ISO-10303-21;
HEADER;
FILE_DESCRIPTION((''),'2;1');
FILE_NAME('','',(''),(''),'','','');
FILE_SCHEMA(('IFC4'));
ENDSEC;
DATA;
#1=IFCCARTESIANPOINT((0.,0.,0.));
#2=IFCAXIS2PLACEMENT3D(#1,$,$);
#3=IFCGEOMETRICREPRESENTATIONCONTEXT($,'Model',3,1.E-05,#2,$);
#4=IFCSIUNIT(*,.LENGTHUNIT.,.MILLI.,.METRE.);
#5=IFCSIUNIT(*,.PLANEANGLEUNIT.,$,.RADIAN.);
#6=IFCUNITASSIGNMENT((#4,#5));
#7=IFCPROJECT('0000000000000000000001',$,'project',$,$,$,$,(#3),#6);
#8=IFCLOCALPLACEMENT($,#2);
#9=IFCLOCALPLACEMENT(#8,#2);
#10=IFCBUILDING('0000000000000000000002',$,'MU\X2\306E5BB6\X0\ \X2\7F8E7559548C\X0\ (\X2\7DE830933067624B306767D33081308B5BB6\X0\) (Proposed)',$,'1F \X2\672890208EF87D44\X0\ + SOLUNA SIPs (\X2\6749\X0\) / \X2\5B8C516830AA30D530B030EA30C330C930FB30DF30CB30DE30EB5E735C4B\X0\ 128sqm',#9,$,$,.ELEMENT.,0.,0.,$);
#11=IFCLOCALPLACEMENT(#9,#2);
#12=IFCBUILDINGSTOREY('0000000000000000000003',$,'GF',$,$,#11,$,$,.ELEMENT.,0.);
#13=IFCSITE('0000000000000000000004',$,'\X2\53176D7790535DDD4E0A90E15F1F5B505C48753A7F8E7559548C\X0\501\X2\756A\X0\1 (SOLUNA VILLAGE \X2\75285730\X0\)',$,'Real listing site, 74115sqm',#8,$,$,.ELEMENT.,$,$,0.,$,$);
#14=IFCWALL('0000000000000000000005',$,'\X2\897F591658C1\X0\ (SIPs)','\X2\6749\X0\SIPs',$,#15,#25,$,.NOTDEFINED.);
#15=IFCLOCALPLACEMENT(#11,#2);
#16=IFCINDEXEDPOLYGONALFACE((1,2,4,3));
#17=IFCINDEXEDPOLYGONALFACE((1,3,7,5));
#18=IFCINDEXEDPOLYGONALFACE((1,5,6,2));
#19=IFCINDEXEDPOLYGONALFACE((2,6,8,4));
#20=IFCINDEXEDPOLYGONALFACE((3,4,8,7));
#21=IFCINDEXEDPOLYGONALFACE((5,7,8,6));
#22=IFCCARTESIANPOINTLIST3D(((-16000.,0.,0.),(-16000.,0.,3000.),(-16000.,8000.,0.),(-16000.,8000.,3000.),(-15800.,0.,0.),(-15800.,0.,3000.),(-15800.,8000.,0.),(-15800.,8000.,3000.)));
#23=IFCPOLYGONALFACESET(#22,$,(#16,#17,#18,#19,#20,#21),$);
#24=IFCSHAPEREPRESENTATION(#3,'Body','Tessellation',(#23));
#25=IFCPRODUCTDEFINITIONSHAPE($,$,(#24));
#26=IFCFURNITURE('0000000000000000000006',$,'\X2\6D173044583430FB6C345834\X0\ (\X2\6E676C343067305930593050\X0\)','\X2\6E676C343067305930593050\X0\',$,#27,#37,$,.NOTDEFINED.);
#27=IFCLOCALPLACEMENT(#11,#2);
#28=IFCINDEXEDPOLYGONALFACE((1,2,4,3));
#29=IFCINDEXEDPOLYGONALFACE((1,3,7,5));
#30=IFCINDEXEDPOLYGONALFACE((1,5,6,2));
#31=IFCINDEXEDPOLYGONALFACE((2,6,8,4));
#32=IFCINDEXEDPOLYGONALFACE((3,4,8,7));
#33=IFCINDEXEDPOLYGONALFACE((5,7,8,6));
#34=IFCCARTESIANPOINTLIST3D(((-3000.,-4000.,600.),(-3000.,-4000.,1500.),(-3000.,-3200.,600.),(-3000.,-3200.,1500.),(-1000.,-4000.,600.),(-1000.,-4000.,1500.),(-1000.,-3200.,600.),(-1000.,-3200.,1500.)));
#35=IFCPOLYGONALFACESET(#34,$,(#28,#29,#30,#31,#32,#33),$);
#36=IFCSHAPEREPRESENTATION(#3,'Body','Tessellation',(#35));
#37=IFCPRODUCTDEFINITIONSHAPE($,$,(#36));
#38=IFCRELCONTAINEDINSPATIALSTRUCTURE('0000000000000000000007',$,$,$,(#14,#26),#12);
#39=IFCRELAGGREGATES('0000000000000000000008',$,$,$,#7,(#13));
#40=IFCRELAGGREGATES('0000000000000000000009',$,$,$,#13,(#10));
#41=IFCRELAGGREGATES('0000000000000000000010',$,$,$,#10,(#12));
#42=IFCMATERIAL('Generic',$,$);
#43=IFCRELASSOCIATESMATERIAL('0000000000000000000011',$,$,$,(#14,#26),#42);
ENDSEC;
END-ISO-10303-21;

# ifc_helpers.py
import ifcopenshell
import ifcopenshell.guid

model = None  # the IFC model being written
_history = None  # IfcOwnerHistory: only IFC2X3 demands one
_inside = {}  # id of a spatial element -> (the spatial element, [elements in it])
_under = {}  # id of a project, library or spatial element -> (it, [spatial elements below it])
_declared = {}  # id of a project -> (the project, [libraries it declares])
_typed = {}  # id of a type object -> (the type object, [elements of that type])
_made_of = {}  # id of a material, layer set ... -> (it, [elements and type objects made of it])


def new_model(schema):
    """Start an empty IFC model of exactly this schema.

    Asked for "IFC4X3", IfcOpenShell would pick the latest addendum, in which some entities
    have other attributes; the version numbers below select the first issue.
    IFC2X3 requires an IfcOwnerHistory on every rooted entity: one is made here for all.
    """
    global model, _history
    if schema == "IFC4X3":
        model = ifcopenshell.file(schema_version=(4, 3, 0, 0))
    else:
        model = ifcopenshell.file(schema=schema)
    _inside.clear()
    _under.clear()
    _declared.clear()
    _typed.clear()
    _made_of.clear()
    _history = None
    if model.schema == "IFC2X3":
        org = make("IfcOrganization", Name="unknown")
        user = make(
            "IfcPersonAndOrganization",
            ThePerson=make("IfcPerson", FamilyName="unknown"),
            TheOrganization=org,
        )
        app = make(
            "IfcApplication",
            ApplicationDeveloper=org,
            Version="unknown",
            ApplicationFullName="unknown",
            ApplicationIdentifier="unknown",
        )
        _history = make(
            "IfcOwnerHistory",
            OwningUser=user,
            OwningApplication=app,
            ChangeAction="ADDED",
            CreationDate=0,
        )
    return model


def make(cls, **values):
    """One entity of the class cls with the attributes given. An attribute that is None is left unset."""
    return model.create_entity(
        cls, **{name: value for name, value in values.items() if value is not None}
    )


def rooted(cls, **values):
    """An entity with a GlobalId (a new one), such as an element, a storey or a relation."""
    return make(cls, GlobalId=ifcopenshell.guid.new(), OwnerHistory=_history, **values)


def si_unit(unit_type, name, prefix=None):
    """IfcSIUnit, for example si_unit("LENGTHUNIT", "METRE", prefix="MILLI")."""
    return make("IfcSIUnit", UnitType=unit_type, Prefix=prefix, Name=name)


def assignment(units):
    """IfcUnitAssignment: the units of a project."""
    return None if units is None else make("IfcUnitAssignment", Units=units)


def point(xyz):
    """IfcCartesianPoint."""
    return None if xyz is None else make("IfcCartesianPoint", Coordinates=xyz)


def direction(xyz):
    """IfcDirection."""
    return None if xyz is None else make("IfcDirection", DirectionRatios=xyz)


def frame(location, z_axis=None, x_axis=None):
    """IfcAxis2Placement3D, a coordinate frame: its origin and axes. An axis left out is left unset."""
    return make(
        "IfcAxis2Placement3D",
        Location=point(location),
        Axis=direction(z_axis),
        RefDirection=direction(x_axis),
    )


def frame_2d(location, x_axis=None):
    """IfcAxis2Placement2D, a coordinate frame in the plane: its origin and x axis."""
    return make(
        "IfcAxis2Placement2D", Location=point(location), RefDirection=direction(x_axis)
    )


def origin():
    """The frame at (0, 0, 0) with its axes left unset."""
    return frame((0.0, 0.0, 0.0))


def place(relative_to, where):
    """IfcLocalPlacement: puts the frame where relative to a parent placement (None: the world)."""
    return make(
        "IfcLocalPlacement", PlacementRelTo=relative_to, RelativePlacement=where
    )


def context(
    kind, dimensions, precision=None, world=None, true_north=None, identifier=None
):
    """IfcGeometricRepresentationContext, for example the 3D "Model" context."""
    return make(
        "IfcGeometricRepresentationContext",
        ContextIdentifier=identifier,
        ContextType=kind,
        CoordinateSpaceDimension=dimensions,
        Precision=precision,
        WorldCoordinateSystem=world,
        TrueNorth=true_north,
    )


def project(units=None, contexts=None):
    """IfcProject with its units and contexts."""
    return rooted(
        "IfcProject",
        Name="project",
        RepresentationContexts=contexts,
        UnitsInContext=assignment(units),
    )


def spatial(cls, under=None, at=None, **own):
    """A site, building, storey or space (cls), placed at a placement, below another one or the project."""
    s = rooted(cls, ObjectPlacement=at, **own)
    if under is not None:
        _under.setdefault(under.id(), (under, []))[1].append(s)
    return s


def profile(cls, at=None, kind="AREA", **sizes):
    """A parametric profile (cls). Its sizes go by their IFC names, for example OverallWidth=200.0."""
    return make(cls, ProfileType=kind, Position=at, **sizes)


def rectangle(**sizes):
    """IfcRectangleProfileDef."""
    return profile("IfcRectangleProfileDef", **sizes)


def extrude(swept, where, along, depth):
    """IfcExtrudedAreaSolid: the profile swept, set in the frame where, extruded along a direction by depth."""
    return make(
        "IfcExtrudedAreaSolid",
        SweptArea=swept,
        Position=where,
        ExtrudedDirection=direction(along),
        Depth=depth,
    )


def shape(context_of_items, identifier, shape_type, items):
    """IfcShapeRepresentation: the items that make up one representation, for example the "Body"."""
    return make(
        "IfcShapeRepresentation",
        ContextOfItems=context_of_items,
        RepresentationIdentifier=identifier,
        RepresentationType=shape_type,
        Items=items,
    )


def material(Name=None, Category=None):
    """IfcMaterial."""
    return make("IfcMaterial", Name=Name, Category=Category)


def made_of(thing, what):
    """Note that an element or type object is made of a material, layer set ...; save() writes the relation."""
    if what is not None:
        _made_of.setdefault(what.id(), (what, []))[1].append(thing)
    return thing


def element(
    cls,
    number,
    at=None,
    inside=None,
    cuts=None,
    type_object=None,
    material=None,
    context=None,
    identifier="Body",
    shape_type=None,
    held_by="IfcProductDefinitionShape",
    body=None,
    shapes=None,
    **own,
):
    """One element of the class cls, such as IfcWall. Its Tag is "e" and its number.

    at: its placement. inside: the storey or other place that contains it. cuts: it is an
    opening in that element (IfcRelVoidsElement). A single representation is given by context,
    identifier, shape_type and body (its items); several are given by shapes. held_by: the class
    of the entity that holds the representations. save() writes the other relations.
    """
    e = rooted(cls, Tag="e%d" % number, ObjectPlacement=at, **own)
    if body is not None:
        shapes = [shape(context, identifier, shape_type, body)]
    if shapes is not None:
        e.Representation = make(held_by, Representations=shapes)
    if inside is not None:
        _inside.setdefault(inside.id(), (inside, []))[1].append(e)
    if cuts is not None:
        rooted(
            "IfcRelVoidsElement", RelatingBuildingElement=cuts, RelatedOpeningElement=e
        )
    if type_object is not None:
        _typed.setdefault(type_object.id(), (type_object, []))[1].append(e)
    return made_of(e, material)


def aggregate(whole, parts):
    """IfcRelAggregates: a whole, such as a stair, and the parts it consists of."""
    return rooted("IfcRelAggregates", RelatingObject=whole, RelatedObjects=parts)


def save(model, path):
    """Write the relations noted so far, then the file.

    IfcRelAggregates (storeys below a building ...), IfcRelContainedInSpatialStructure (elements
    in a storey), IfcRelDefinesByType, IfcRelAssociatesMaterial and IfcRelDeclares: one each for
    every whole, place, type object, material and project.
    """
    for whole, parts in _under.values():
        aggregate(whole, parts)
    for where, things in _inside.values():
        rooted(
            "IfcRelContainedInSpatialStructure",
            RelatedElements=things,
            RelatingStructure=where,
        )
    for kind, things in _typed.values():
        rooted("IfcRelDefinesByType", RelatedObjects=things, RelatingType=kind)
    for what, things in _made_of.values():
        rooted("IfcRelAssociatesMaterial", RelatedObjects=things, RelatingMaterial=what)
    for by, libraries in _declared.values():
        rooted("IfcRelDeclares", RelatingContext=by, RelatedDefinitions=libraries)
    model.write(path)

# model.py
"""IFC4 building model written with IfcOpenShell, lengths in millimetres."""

from ifc_helpers import new_model, si_unit, frame, frame_2d, origin, place, context, project, spatial, rectangle, extrude, material, element, save


model = new_model("IFC4")

# Units and contexts
model_context = context("Model", 3, precision=1e-05, world=origin())
ifc_project = project(units=[si_unit("LENGTHUNIT", "METRE", prefix="MILLI"), si_unit("PLANEANGLEUNIT", "RADIAN")], contexts=[model_context])

# Site, building, storey
site_placement = place(None, origin())
site = spatial("IfcSite", under=ifc_project, at=site_placement, Name="北海道川上郡弟子屈町美留和501番1 (SOLUNA VILLAGE 用地)", ObjectType="Real listing site, 74115sqm", CompositionType="ELEMENT", RefElevation=0.0)
building_placement = place(site_placement, origin())
building = spatial("IfcBuilding", under=site, at=building_placement, Name="MUの家 美留和 (編んで手で染める家) (Proposed)", ObjectType="1F 木造軸組 + SOLUNA SIPs (杉) / 完全オフグリッド・ミニマル平屋 128sqm", CompositionType="ELEMENT", ElevationOfRefHeight=0.0, ElevationOfTerrain=0.0)
storey_placement = place(building_placement, origin())
storey = spatial("IfcBuildingStorey", under=building, at=storey_placement, Name="GF", CompositionType="ELEMENT", Elevation=0.0)

# Shared definitions
ifc_material_1 = material(Name="Generic")

# Wall
wall_1_placement = place(storey_placement, frame((-8000.0, 0.0, 0.0)))
element("IfcWall", 1, at=wall_1_placement, inside=storey, material=ifc_material_1, Name="西外壁 (SIPs)", Description="杉SIPs", PredefinedType="NOTDEFINED", context=model_context, shape_type="SweptSolid", body=[
    extrude(rectangle(XDim=200.0, YDim=8000.0, at=frame_2d((100.0, 4000.0))), frame((-8000.0, 0.0, 0.0)), (0.0, 0.0, 1.0), 3000.0),
])

# Furniture
furniture_1_placement = place(storey_placement, frame((-1500.0, -2000.0, 300.0)))
element("IfcFurniture", 2, at=furniture_1_placement, inside=storey, material=ifc_material_1, Name="洗い場・水場 (湧水ですすぐ)", Description="湧水ですすぐ", PredefinedType="NOTDEFINED", context=model_context, shape_type="SweptSolid", body=[
    extrude(rectangle(XDim=2000.0, YDim=800.0, at=frame_2d((1000.0, 400.0))), frame((-1500.0, -2000.0, 300.0)), (0.0, 0.0, 1.0), 900.0),
])

save(model, "model.ifc")
